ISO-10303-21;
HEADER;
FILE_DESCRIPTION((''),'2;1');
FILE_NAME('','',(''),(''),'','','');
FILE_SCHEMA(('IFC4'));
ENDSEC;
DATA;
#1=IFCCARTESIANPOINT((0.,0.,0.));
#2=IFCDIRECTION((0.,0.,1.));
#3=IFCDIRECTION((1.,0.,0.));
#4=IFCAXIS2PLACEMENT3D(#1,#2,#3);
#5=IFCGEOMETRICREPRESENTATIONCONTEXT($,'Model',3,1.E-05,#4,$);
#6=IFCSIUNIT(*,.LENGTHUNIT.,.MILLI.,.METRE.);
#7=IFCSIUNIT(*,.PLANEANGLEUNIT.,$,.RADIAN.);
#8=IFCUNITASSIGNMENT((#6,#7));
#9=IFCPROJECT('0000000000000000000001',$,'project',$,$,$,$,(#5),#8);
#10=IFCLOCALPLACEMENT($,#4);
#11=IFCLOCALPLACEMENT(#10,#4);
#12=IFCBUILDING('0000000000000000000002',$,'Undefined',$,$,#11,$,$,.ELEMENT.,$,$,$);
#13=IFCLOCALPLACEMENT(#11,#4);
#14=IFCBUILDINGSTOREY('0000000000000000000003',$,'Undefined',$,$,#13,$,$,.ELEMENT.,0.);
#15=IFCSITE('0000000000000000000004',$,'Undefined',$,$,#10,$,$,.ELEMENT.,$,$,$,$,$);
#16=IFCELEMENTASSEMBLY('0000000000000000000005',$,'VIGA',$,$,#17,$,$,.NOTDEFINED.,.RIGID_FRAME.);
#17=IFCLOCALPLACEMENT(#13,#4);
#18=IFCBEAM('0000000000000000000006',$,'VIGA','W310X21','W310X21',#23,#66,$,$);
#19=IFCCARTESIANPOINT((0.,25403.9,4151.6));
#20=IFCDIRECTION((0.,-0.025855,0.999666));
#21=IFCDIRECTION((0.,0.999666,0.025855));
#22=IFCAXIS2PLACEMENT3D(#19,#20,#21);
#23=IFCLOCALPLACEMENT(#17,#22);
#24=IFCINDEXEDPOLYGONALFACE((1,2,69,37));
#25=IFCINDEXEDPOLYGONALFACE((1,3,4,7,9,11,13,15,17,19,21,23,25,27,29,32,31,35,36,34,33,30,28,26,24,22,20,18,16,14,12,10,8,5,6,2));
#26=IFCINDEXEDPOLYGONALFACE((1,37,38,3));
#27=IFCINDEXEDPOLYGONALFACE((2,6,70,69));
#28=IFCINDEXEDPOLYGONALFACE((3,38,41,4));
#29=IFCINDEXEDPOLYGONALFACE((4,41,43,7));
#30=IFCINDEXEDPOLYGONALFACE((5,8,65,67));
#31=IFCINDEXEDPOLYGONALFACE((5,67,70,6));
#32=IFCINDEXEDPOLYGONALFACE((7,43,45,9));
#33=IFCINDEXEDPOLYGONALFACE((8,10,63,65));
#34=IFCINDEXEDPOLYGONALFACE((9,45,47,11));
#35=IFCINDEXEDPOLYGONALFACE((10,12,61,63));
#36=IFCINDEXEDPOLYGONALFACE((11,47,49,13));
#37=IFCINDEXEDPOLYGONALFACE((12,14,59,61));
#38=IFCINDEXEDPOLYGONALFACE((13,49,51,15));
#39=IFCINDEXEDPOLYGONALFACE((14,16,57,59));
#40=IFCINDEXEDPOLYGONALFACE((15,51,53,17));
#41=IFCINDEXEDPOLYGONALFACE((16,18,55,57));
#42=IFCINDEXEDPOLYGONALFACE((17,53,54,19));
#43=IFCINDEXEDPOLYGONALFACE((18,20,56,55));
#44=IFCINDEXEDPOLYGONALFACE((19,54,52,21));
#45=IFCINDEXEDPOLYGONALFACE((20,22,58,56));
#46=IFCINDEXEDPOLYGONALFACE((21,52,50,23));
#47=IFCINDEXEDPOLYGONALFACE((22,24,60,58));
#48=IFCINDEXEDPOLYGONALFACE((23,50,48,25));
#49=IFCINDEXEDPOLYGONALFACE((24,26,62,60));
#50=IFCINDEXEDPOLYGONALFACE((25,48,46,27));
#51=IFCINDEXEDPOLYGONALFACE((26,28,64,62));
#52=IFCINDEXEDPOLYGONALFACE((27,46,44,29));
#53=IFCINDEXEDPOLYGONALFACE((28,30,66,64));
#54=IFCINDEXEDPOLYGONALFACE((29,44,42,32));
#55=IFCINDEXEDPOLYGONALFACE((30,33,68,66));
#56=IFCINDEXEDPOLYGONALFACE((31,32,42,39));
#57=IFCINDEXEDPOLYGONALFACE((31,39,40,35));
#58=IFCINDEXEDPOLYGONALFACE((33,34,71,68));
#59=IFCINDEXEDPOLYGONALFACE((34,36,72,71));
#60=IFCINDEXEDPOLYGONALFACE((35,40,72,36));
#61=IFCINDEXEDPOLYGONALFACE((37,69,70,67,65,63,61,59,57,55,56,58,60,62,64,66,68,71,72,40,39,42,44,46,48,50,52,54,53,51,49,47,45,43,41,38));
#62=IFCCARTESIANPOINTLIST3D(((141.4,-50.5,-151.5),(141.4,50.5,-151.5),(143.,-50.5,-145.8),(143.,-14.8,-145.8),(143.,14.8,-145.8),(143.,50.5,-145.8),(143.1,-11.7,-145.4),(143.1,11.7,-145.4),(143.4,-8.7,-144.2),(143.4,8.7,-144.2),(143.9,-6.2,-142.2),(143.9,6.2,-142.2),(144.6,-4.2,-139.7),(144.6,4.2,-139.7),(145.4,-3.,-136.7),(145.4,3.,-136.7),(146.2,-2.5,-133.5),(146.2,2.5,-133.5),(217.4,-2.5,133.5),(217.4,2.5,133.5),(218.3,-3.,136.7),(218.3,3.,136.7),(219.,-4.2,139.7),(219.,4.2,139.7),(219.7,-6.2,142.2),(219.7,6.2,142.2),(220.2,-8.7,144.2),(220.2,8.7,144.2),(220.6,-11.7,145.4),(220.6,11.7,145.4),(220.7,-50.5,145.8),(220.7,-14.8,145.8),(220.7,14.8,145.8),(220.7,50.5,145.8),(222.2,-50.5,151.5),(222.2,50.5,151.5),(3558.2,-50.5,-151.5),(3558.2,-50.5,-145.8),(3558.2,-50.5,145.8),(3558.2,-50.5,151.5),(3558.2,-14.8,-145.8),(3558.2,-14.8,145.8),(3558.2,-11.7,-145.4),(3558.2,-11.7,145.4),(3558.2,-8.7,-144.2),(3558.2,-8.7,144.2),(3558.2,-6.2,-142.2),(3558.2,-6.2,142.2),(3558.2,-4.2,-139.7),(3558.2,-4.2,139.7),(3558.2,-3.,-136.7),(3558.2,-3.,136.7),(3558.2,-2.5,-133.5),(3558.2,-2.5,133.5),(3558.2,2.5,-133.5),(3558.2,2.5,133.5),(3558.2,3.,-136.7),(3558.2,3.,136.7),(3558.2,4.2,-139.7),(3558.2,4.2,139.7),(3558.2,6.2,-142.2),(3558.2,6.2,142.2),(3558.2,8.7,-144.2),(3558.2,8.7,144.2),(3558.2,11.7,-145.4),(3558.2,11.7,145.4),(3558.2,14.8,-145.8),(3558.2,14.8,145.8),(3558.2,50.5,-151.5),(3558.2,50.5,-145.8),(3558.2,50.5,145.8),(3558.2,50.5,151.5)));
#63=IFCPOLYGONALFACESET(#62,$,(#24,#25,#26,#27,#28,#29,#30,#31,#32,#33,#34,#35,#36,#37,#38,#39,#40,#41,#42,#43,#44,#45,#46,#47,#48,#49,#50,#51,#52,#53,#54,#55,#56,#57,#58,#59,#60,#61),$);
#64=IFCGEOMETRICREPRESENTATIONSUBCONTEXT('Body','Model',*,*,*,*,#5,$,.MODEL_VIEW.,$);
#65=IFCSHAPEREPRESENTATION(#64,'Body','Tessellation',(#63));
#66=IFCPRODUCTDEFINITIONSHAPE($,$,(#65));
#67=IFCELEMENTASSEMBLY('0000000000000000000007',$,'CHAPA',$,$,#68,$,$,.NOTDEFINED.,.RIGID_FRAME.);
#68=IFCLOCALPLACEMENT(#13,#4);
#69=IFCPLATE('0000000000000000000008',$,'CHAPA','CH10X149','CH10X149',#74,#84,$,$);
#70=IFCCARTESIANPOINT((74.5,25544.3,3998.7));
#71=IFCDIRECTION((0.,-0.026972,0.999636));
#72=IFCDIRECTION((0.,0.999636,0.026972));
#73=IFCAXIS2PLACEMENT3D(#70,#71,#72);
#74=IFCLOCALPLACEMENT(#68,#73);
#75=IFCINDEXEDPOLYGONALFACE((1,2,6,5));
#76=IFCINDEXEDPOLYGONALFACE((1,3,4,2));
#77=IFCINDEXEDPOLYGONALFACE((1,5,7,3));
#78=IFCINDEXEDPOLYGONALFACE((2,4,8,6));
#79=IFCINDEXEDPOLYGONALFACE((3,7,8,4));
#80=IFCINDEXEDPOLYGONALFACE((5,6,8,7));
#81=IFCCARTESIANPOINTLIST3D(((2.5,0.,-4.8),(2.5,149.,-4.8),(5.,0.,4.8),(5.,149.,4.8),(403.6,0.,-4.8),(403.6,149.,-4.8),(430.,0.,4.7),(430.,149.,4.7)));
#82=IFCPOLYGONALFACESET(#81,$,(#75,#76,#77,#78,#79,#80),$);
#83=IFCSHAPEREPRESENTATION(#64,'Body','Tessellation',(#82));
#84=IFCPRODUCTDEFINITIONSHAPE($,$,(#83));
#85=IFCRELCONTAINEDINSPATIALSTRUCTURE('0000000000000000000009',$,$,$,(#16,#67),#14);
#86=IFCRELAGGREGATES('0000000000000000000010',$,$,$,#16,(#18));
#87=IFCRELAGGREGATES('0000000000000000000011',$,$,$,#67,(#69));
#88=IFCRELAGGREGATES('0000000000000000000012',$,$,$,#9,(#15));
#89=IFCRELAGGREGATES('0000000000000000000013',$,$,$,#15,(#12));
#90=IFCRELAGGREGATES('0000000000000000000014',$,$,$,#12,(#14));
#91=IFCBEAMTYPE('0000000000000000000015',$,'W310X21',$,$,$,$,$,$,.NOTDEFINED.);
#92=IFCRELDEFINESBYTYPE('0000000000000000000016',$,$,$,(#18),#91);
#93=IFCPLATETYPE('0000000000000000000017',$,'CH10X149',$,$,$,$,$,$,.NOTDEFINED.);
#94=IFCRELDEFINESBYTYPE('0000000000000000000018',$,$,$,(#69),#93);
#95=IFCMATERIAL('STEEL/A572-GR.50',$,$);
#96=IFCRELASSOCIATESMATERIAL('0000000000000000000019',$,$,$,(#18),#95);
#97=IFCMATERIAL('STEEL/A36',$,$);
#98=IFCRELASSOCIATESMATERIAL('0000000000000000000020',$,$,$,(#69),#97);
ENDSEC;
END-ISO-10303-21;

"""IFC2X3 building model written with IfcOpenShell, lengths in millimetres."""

from ifc_helpers import new_model, si_unit, frame, origin_with_axes, origin_2d_with_axis, place, context, subcontext, project, spatial, polyline, i_section, outline, extrude, clip, halfspace, material, type_object, element, aggregate, save


model = new_model("IFC2X3")

# Units and contexts
model_context = context("Model", 3, precision=1e-05, world=origin_with_axes())
body_context = subcontext(model_context, "Body", "Model", "MODEL_VIEW")
ifc_project = project(units=[si_unit("LENGTHUNIT", "METRE", prefix="MILLI"), si_unit("PLANEANGLEUNIT", "RADIAN")], contexts=[model_context])

# Site, building, storey
site_placement = place(None, origin_with_axes())
site = spatial("IfcSite", under=ifc_project, at=site_placement, Name="Undefined", CompositionType="ELEMENT")
building_placement = place(site_placement, origin_with_axes())
building = spatial("IfcBuilding", under=site, at=building_placement, Name="Undefined", CompositionType="ELEMENT")
storey_placement = place(building_placement, origin_with_axes())
storey = spatial("IfcBuildingStorey", under=building, at=storey_placement, Name="Undefined", CompositionType="ELEMENT", Elevation=0.0)

# Element assembly, beam
ifc_material_1 = material(Name="STEEL/A572-GR.50")
assembly_1_placement = place(storey_placement, origin_with_axes())
assembly_1 = element("IfcElementAssembly", 1, at=assembly_1_placement, inside=storey, Name="VIGA", AssemblyPlace="NOTDEFINED", PredefinedType="RIGID_FRAME")
beam_type_1 = type_object("IfcBeamType", Name="W310X21", PredefinedType="NOTDEFINED")
beam_1_placement = place(assembly_1_placement, frame((0.0, 25403.9, 4151.6), z_axis=(0.0, -0.025855, 0.999666), x_axis=(0.0, 0.999666, 0.025855)))
beam_1 = element("IfcBeam", 2, at=beam_1_placement, type_object=beam_type_1, material=ifc_material_1, Name="VIGA", Description="W310X21", ObjectType="W310X21", context=body_context, shape_type="Clipping", body=[
    clip(extrude(i_section(OverallWidth=101.0, OverallDepth=303.0, WebThickness=5.1, FlangeThickness=5.7, FilletRadius=12.3, at=origin_2d_with_axis()), frame((3558.2, 0.0, 0.0), z_axis=(-1.0, 0.0, 0.0), x_axis=(0.0, -1.0, 0.0)), (0.0, 0.0, 1.0), 3558.2), halfspace(frame((141.4, -50.5, -151.7), z_axis=(-0.966259, 0.0, 0.257573), x_axis=(0.0, 1.0, 0.0)), False)),
])
aggregate(assembly_1, [beam_1])

# Shared definitions
ifc_material_2 = material(Name="STEEL/A36")

# Element assembly, plate
plate_type_1 = type_object("IfcPlateType", Name="CH10X149", PredefinedType="NOTDEFINED")
assembly_2_placement = place(storey_placement, origin_with_axes())
assembly_2 = element("IfcElementAssembly", 3, at=assembly_2_placement, inside=storey, Name="CHAPA", AssemblyPlace="NOTDEFINED", PredefinedType="RIGID_FRAME")
plate_1_placement = place(assembly_2_placement, frame((74.5, 25544.3, 3998.7), z_axis=(0.0, -0.026972, 0.999636), x_axis=(0.0, 0.999636, 0.026972)))
plate_1 = element("IfcPlate", 4, at=plate_1_placement, type_object=plate_type_1, material=ifc_material_2, Name="CHAPA", Description="CH10X149", ObjectType="CH10X149", context=body_context, shape_type="Clipping", body=[
    clip(clip(extrude(outline(polyline([(0.0, 0.0), (430.0, 0.0), (430.0, 149.0), (0.0, 149.0), (0.0, 0.0)])), frame((0.0, 0.0, -4.8), z_axis=(0.0, 0.0, 1.0), x_axis=(1.0, 0.0, 0.0)), (0.0, 0.0, 1.0), 9.5), halfspace(frame((403.6, -500.0, -4.8), z_axis=(0.33881, 0.0, -0.940855), x_axis=(0.940855, 0.0, 0.33881)), False)), halfspace(frame((5.0, -500.0, 4.7), z_axis=(-0.965989, 0.0, 0.258583), x_axis=(-0.258583, 0.0, -0.965989)), False)),
])
aggregate(assembly_2, [plate_1])

save(model, "model.ifc")
